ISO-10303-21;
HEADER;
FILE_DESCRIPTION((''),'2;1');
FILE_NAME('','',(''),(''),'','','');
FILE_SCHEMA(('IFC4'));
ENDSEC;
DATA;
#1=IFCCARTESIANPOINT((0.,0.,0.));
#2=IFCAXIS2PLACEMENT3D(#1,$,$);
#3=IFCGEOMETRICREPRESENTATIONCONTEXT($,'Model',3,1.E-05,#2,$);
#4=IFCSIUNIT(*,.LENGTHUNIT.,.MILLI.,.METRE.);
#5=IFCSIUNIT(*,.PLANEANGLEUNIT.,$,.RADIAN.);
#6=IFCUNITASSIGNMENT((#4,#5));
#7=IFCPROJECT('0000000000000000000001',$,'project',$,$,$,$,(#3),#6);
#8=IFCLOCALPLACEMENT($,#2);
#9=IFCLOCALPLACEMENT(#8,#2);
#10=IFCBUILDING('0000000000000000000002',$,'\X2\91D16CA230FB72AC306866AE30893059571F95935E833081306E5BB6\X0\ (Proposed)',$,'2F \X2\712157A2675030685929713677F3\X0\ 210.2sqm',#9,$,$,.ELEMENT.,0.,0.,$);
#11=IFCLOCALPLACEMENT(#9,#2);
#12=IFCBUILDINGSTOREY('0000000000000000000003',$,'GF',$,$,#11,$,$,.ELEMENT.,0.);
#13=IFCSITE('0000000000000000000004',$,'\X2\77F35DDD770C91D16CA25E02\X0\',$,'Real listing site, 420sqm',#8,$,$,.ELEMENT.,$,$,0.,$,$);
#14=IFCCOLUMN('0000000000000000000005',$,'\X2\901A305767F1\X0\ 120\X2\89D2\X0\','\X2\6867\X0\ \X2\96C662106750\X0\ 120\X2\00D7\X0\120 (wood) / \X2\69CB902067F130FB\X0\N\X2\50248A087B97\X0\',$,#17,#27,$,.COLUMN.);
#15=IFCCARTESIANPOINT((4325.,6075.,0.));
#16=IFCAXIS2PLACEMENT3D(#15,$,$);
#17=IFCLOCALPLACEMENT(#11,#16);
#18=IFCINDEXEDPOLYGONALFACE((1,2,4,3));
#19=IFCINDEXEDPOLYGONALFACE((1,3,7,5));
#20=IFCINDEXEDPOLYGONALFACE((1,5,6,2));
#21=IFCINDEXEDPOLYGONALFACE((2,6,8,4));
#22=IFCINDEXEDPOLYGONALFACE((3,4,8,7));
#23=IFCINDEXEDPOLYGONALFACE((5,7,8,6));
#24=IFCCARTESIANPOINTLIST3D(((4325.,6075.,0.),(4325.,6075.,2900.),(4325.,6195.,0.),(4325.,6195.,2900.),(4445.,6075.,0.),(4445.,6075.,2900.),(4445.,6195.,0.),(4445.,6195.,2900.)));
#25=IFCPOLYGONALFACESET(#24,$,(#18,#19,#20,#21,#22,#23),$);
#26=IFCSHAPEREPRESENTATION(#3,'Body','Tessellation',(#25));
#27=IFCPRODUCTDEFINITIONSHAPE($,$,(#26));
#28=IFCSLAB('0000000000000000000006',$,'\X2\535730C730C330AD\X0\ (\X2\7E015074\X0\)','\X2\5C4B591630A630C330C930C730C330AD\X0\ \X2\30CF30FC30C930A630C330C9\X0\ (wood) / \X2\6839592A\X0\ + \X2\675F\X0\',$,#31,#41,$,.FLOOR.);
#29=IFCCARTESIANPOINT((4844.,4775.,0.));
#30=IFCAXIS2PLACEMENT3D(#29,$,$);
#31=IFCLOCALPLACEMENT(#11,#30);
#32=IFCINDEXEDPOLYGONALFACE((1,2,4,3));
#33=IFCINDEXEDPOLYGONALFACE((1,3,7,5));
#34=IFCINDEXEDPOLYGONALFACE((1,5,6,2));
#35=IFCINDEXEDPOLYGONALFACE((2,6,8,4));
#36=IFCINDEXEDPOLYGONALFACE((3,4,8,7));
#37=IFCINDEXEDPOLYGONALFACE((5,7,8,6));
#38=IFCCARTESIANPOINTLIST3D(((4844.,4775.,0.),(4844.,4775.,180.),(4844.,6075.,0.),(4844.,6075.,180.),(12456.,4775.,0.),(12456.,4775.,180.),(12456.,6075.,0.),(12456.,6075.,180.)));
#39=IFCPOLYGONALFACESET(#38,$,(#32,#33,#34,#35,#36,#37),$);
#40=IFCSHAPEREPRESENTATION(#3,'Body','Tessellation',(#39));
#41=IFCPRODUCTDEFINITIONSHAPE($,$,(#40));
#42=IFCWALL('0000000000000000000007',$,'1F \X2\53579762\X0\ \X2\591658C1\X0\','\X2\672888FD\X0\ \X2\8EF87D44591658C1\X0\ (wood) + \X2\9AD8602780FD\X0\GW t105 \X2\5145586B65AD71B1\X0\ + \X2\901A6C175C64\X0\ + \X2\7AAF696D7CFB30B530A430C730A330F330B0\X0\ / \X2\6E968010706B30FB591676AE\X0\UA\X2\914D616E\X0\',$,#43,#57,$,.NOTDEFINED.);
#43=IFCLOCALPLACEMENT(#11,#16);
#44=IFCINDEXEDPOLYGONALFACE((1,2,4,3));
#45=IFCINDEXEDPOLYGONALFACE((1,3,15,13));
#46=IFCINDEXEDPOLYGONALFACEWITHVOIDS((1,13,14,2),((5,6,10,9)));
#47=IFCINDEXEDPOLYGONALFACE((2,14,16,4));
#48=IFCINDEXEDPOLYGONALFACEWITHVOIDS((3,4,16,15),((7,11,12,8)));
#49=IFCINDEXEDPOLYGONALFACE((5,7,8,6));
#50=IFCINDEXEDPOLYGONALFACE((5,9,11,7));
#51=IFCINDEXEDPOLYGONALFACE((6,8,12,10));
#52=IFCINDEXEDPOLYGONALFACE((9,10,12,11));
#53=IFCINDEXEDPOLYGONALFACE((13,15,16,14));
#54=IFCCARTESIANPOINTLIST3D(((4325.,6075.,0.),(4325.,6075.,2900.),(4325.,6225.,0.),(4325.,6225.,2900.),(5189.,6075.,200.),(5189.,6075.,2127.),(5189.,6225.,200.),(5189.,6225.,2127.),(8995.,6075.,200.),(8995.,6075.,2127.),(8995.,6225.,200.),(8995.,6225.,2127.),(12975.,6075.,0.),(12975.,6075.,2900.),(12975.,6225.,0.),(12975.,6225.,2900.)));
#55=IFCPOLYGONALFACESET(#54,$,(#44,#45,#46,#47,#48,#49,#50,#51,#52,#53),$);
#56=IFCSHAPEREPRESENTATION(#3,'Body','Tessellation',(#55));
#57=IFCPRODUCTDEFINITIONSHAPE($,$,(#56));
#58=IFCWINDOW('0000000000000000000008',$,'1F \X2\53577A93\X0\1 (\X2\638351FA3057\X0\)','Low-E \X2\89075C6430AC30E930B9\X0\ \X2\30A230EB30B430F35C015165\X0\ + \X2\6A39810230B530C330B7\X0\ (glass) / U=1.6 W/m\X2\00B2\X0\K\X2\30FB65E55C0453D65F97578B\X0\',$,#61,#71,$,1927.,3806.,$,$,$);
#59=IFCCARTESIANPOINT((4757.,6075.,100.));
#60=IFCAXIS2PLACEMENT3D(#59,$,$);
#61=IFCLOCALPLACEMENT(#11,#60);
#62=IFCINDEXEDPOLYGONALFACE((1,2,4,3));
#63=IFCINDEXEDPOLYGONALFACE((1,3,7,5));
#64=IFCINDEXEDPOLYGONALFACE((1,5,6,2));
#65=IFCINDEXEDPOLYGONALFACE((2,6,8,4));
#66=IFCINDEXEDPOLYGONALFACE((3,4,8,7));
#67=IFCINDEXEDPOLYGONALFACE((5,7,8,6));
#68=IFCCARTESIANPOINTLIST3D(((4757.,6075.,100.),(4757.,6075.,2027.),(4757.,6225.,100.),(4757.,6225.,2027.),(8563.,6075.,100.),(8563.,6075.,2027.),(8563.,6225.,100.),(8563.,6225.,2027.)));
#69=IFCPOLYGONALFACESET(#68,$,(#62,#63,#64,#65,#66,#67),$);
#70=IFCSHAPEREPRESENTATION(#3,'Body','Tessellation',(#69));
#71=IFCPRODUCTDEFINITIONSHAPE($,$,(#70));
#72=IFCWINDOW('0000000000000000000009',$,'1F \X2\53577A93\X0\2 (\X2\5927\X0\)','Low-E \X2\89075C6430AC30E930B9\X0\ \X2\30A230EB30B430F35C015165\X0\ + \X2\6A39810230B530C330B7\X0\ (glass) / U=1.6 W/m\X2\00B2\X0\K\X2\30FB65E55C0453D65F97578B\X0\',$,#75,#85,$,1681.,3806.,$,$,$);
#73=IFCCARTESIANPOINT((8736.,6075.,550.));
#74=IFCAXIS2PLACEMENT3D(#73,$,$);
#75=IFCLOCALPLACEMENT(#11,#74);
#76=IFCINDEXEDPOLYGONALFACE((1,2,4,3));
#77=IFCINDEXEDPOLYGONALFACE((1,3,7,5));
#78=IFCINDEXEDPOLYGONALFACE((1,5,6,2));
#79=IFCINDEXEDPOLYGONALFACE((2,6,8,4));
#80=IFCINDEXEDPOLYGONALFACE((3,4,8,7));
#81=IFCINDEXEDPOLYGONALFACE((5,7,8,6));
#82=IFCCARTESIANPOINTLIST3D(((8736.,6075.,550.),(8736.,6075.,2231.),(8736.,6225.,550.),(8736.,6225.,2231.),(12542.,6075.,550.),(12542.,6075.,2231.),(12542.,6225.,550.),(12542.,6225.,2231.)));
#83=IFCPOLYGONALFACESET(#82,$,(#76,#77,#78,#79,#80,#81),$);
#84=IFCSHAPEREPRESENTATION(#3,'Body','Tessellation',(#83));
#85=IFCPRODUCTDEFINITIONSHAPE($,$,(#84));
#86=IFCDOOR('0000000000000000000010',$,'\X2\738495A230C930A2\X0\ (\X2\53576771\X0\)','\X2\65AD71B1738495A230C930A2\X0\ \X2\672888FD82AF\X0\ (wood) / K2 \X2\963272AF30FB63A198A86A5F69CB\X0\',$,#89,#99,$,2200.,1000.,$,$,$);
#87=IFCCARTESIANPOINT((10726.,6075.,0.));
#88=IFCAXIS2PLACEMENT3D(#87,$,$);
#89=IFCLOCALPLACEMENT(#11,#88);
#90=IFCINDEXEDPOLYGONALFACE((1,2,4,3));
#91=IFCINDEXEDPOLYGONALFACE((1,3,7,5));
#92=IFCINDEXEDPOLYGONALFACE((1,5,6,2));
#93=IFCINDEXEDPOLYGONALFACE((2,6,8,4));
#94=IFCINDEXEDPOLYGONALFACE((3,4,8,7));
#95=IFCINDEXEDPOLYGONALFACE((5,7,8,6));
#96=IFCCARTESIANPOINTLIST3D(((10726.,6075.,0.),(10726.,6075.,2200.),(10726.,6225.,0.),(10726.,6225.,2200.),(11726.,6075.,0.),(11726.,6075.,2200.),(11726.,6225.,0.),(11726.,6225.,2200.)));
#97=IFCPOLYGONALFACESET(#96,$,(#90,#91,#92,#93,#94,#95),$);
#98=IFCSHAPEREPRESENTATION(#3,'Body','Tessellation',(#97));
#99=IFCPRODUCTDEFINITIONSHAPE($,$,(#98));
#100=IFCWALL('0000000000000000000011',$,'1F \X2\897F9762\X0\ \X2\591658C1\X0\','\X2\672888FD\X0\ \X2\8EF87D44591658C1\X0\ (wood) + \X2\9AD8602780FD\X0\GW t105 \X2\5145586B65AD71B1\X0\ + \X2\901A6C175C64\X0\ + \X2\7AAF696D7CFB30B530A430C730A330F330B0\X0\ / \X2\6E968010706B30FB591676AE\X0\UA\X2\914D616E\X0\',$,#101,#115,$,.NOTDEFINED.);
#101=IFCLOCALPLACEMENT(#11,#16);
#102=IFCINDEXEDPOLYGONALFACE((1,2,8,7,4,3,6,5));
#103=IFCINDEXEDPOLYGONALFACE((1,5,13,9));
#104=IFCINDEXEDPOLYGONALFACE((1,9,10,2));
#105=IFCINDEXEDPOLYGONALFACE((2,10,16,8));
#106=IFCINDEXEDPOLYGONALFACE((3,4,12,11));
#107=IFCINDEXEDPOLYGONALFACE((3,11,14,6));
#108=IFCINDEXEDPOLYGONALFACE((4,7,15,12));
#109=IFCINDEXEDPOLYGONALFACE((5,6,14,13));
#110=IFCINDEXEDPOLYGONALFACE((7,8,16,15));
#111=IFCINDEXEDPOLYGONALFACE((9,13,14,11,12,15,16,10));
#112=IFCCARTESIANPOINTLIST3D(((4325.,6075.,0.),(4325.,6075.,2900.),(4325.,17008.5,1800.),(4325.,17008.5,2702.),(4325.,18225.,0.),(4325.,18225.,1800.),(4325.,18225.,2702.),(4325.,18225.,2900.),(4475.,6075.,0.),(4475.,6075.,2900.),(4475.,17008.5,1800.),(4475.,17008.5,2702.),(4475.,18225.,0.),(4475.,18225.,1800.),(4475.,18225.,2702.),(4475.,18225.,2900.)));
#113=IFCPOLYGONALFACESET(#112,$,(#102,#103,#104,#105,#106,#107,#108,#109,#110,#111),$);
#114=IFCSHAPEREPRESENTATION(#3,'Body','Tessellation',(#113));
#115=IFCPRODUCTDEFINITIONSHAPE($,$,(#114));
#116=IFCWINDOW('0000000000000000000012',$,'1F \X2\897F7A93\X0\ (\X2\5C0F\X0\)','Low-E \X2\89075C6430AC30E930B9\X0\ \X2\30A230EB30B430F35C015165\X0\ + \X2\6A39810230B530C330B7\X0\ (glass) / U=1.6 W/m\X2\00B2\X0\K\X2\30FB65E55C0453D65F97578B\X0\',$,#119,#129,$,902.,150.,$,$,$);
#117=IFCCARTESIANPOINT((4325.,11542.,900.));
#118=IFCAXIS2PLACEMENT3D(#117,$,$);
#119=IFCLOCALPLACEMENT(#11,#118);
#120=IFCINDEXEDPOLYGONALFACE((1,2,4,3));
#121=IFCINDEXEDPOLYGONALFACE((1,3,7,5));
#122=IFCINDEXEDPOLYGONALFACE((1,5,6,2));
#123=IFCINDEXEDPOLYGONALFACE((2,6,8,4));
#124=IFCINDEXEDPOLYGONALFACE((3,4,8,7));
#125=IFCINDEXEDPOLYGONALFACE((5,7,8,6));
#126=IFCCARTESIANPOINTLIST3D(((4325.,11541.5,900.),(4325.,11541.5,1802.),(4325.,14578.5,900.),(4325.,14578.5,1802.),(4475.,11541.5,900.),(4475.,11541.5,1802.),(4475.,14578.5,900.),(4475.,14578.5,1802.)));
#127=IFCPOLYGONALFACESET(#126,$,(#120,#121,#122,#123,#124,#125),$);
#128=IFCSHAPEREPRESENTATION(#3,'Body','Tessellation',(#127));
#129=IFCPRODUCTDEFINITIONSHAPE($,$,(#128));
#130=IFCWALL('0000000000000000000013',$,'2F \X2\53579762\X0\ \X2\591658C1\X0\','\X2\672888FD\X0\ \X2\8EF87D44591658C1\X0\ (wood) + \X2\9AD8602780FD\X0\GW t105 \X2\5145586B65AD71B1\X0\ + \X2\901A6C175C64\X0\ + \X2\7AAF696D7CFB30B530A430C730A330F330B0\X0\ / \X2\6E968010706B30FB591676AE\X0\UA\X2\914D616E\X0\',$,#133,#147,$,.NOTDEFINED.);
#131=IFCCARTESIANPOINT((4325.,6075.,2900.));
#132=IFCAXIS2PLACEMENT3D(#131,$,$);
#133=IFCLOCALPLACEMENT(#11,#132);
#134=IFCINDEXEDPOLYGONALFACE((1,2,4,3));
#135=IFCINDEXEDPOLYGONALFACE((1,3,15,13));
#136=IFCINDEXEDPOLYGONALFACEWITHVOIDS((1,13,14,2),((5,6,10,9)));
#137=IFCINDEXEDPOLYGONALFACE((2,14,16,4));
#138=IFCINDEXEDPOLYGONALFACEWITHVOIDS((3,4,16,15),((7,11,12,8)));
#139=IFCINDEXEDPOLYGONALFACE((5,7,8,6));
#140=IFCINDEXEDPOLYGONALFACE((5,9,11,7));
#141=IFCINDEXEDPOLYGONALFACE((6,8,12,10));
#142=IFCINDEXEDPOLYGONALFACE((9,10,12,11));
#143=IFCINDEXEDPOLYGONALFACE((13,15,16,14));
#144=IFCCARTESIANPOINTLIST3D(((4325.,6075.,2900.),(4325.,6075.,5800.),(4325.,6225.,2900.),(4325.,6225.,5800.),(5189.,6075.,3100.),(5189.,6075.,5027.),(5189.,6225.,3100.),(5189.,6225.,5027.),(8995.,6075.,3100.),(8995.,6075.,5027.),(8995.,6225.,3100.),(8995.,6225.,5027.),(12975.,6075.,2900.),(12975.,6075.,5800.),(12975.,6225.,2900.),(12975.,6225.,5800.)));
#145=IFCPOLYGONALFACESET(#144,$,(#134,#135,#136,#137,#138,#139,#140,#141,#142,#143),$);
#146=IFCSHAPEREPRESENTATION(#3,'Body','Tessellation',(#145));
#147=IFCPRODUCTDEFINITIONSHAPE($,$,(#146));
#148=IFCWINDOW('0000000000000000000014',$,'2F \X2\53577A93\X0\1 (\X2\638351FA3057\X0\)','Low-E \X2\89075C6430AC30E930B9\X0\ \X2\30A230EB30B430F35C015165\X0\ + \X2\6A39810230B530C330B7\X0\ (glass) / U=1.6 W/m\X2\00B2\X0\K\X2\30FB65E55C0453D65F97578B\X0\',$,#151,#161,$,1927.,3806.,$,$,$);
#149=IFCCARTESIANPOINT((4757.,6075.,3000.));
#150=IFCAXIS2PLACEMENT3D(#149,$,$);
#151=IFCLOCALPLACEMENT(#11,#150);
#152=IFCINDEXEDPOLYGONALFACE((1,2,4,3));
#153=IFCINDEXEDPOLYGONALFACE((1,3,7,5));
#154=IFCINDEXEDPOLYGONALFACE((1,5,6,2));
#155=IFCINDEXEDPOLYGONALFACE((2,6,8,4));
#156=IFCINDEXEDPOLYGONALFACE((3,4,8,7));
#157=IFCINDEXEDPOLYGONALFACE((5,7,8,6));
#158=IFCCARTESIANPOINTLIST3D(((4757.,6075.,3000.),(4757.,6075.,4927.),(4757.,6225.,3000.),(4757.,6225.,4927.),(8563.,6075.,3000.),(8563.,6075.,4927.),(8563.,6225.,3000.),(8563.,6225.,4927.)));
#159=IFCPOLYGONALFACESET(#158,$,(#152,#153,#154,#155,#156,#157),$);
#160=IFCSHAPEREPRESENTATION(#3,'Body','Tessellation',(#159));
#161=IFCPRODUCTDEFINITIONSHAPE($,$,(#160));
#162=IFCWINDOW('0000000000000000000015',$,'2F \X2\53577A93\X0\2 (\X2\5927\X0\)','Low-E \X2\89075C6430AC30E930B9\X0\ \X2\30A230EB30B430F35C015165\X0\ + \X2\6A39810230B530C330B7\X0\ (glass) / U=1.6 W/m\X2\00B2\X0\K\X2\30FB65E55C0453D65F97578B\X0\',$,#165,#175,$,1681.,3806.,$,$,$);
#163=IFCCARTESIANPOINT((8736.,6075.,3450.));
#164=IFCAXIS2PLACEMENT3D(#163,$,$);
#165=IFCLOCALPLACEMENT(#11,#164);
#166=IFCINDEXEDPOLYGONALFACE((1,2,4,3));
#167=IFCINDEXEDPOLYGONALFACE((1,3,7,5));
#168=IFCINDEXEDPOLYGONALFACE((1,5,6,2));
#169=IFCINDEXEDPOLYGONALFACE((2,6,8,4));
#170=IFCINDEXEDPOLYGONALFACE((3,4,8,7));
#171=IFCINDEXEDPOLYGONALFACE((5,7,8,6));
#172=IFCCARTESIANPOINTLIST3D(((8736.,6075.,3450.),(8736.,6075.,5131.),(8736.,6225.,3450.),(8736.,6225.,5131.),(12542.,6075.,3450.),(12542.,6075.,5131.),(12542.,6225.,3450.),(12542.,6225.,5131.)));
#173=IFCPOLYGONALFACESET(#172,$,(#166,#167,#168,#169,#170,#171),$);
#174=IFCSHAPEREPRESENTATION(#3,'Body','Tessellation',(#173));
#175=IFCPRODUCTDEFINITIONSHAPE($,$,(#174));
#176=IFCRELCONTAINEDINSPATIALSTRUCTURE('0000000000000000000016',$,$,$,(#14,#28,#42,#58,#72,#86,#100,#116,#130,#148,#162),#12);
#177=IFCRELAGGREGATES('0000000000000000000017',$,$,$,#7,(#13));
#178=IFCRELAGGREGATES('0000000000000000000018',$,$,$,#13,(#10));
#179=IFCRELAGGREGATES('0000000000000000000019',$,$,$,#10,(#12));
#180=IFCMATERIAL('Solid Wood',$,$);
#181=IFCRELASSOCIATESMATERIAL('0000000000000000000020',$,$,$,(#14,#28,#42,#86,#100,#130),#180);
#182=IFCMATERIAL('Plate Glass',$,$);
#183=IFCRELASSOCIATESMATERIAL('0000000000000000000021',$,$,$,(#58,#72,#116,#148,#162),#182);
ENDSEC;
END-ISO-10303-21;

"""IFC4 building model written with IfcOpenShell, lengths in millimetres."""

from ifc_helpers import new_model, si_unit, frame, frame_2d, origin, place, context, project, spatial, rectangle, extrude, material, element, fill, save


model = new_model("IFC4")

# Units and contexts
model_context = context("Model", 3, precision=1e-05, world=origin())
ifc_project = project(units=[si_unit("LENGTHUNIT", "METRE", prefix="MILLI"), si_unit("PLANEANGLEUNIT", "RADIAN")], contexts=[model_context])

# Site, building, storey
site_placement = place(None, origin())
site = spatial("IfcSite", under=ifc_project, at=site_placement, Name="石川県金沢市", ObjectType="Real listing site, 420sqm", CompositionType="ELEMENT", RefElevation=0.0)
building_placement = place(site_placement, origin())
building = spatial("IfcBuilding", under=site, at=building_placement, Name="金沢・犬と暮らす土間広めの家 (Proposed)", ObjectType="2F 無垢材と天然石 210.2sqm", CompositionType="ELEMENT", ElevationOfRefHeight=0.0, ElevationOfTerrain=0.0)
storey_placement = place(building_placement, origin())
storey = spatial("IfcBuildingStorey", under=building, at=storey_placement, Name="GF", CompositionType="ELEMENT", Elevation=0.0)

# Column
ifc_material_1 = material(Name="Solid Wood")
column_placement = place(storey_placement, frame((4325.0, 6075.0, 0.0)))
element("IfcColumn", 1, at=column_placement, inside=storey, material=ifc_material_1, Name="通し柱 120角", Description="桧 集成材 120×120 (wood) / 構造柱・N値計算", PredefinedType="COLUMN", context=model_context, shape_type="SweptSolid", body=[
    extrude(rectangle(XDim=120.0, YDim=120.0, at=frame_2d((60.0, 60.0))), frame((4325.0, 6075.0, 0.0)), (0.0, 0.0, 1.0), 2900.0),
])

# Slab
slab_1_placement = place(storey_placement, frame((4844.0, 4775.0, 0.0)))
element("IfcSlab", 2, at=slab_1_placement, inside=storey, material=ifc_material_1, Name="南デッキ (縁側)", Description="屋外ウッドデッキ ハードウッド (wood) / 根太 + 束", PredefinedType="FLOOR", context=model_context, shape_type="SweptSolid", body=[
    extrude(rectangle(XDim=7612.0, YDim=1300.0, at=frame_2d((3806.0, 650.0))), frame((4844.0, 4775.0, 0.0)), (0.0, 0.0, 1.0), 180.0),
])

# Wall, openings, windows, door
wall_1_placement = place(storey_placement, frame((4325.0, 6075.0, 0.0)))
wall_1 = element("IfcWall", 3, at=wall_1_placement, inside=storey, material=ifc_material_1, Name="1F 南面 外壁", Description="木製 軸組外壁 (wood) + 高性能GW t105 充填断熱 + 通気層 + 窯業系サイディング / 準耐火・外皮UA配慮", PredefinedType="NOTDEFINED", context=model_context, shape_type="SweptSolid", body=[
    extrude(rectangle(XDim=8650.0, YDim=150.0, at=frame_2d((4325.0, 75.0))), frame((4325.0, 6075.0, 0.0)), (0.0, 0.0, 1.0), 2900.0),
])
opening_1_placement = place(storey_placement, frame((4757.0, 6075.0, 100.0)))
opening_1 = element("IfcOpeningElement", 4, at=opening_1_placement, cuts=wall_1, PredefinedType="NOTDEFINED", context=model_context, shape_type="SweptSolid", body=[
    extrude(rectangle(XDim=3806.0, YDim=150.0, at=frame_2d((1903.0, 75.0))), frame((4757.0, 6075.0, 100.0)), (0.0, 0.0, 1.0), 1927.0),
])
opening_2_placement = place(storey_placement, frame((8736.0, 6075.0, 550.0)))
opening_2 = element("IfcOpeningElement", 5, at=opening_2_placement, cuts=wall_1, PredefinedType="NOTDEFINED", context=model_context, shape_type="SweptSolid", body=[
    extrude(rectangle(XDim=3806.0, YDim=150.0, at=frame_2d((1903.0, 75.0))), frame((8736.0, 6075.0, 550.0)), (0.0, 0.0, 1.0), 1681.0),
])
opening_3_placement = place(storey_placement, frame((10726.0, 6075.0, 0.0)))
opening_3 = element("IfcOpeningElement", 6, at=opening_3_placement, cuts=wall_1, PredefinedType="NOTDEFINED", context=model_context, shape_type="SweptSolid", body=[
    extrude(rectangle(XDim=1000.0, YDim=150.0, at=frame_2d((500.0, 75.0))), frame((10726.0, 6075.0, 0.0)), (0.0, 0.0, 1.0), 2200.0),
])
ifc_material_2 = material(Name="Plate Glass")
window_1_placement = place(storey_placement, frame((4757.0, 6075.0, 100.0)))
window_1 = element("IfcWindow", 7, at=window_1_placement, inside=storey, material=ifc_material_2, Name="1F 南窓1 (掃出し)", Description="Low-E 複層ガラス アルゴン封入 + 樹脂サッシ (glass) / U=1.6 W/m²K・日射取得型", OverallHeight=1927.0, OverallWidth=3806.0, context=model_context, shape_type="SweptSolid", body=[
    extrude(rectangle(XDim=3806.0, YDim=150.0, at=frame_2d((1903.0, 75.0))), frame((4757.0, 6075.0, 100.0)), (0.0, 0.0, 1.0), 1927.0),
])
fill(opening_1, window_1)
window_2_placement = place(storey_placement, frame((8736.0, 6075.0, 550.0)))
window_2 = element("IfcWindow", 8, at=window_2_placement, inside=storey, material=ifc_material_2, Name="1F 南窓2 (大)", Description="Low-E 複層ガラス アルゴン封入 + 樹脂サッシ (glass) / U=1.6 W/m²K・日射取得型", OverallHeight=1681.0, OverallWidth=3806.0, context=model_context, shape_type="SweptSolid", body=[
    extrude(rectangle(XDim=3806.0, YDim=150.0, at=frame_2d((1903.0, 75.0))), frame((8736.0, 6075.0, 550.0)), (0.0, 0.0, 1.0), 1681.0),
])
fill(opening_2, window_2)
door_placement = place(storey_placement, frame((10726.0, 6075.0, 0.0)))
door = element("IfcDoor", 9, at=door_placement, inside=storey, material=ifc_material_1, Name="玄関ドア (南東)", Description="断熱玄関ドア 木製芯 (wood) / K2 防犯・採風機構", OverallHeight=2200.0, OverallWidth=1000.0, context=model_context, shape_type="SweptSolid", body=[
    extrude(rectangle(XDim=1000.0, YDim=150.0, at=frame_2d((500.0, 75.0))), frame((10726.0, 6075.0, 0.0)), (0.0, 0.0, 1.0), 2200.0),
])
fill(opening_3, door)

# Wall, opening, window
wall_2_placement = place(storey_placement, frame((4325.0, 6075.0, 0.0)))
wall_2 = element("IfcWall", 10, at=wall_2_placement, inside=storey, material=ifc_material_1, Name="1F 西面 外壁", Description="木製 軸組外壁 (wood) + 高性能GW t105 充填断熱 + 通気層 + 窯業系サイディング / 準耐火・外皮UA配慮", PredefinedType="NOTDEFINED", context=model_context, shape_type="SweptSolid", body=[
    extrude(rectangle(XDim=150.0, YDim=12150.0, at=frame_2d((75.0, 6075.0))), frame((4325.0, 6075.0, 0.0)), (0.0, 0.0, 1.0), 2900.0),
])
opening_4_placement = place(storey_placement, frame((4325.0, 11542.0, 900.0)))
opening_4 = element("IfcOpeningElement", 11, at=opening_4_placement, cuts=wall_2, PredefinedType="NOTDEFINED", context=model_context, shape_type="SweptSolid", body=[
    extrude(rectangle(XDim=150.0, YDim=3037.0, at=frame_2d((75.0, 1518.0))), frame((4325.0, 11542.0, 900.0)), (0.0, 0.0, 1.0), 902.0),
])
window_3_placement = place(storey_placement, frame((4325.0, 11542.0, 900.0)))
window_3 = element("IfcWindow", 12, at=window_3_placement, inside=storey, material=ifc_material_2, Name="1F 西窓 (小)", Description="Low-E 複層ガラス アルゴン封入 + 樹脂サッシ (glass) / U=1.6 W/m²K・日射取得型", OverallHeight=902.0, OverallWidth=150.0, context=model_context, shape_type="SweptSolid", body=[
    extrude(rectangle(XDim=150.0, YDim=3037.0, at=frame_2d((75.0, 1518.0))), frame((4325.0, 11542.0, 900.0)), (0.0, 0.0, 1.0), 902.0),
])
fill(opening_4, window_3)

# Wall, openings, windows
wall_3_placement = place(storey_placement, frame((4325.0, 6075.0, 2900.0)))
wall_3 = element("IfcWall", 13, at=wall_3_placement, inside=storey, material=ifc_material_1, Name="2F 南面 外壁", Description="木製 軸組外壁 (wood) + 高性能GW t105 充填断熱 + 通気層 + 窯業系サイディング / 準耐火・外皮UA配慮", PredefinedType="NOTDEFINED", context=model_context, shape_type="SweptSolid", body=[
    extrude(rectangle(XDim=8650.0, YDim=150.0, at=frame_2d((4325.0, 75.0))), frame((4325.0, 6075.0, 2900.0)), (0.0, 0.0, 1.0), 2900.0),
])
opening_5_placement = place(storey_placement, frame((4757.0, 6075.0, 3000.0)))
opening_5 = element("IfcOpeningElement", 14, at=opening_5_placement, cuts=wall_3, PredefinedType="NOTDEFINED", context=model_context, shape_type="SweptSolid", body=[
    extrude(rectangle(XDim=3806.0, YDim=150.0, at=frame_2d((1903.0, 75.0))), frame((4757.0, 6075.0, 3000.0)), (0.0, 0.0, 1.0), 1927.0),
])
opening_6_placement = place(storey_placement, frame((8736.0, 6075.0, 3450.0)))
opening_6 = element("IfcOpeningElement", 15, at=opening_6_placement, cuts=wall_3, PredefinedType="NOTDEFINED", context=model_context, shape_type="SweptSolid", body=[
    extrude(rectangle(XDim=3806.0, YDim=150.0, at=frame_2d((1903.0, 75.0))), frame((8736.0, 6075.0, 3450.0)), (0.0, 0.0, 1.0), 1681.0),
])
window_4_placement = place(storey_placement, frame((4757.0, 6075.0, 3000.0)))
window_4 = element("IfcWindow", 16, at=window_4_placement, inside=storey, material=ifc_material_2, Name="2F 南窓1 (掃出し)", Description="Low-E 複層ガラス アルゴン封入 + 樹脂サッシ (glass) / U=1.6 W/m²K・日射取得型", OverallHeight=1927.0, OverallWidth=3806.0, context=model_context, shape_type="SweptSolid", body=[
    extrude(rectangle(XDim=3806.0, YDim=150.0, at=frame_2d((1903.0, 75.0))), frame((4757.0, 6075.0, 3000.0)), (0.0, 0.0, 1.0), 1927.0),
])
fill(opening_5, window_4)
window_5_placement = place(storey_placement, frame((8736.0, 6075.0, 3450.0)))
window_5 = element("IfcWindow", 17, at=window_5_placement, inside=storey, material=ifc_material_2, Name="2F 南窓2 (大)", Description="Low-E 複層ガラス アルゴン封入 + 樹脂サッシ (glass) / U=1.6 W/m²K・日射取得型", OverallHeight=1681.0, OverallWidth=3806.0, context=model_context, shape_type="SweptSolid", body=[
    extrude(rectangle(XDim=3806.0, YDim=150.0, at=frame_2d((1903.0, 75.0))), frame((8736.0, 6075.0, 3450.0)), (0.0, 0.0, 1.0), 1681.0),
])
fill(opening_6, window_5)

save(model, "model.ifc")
